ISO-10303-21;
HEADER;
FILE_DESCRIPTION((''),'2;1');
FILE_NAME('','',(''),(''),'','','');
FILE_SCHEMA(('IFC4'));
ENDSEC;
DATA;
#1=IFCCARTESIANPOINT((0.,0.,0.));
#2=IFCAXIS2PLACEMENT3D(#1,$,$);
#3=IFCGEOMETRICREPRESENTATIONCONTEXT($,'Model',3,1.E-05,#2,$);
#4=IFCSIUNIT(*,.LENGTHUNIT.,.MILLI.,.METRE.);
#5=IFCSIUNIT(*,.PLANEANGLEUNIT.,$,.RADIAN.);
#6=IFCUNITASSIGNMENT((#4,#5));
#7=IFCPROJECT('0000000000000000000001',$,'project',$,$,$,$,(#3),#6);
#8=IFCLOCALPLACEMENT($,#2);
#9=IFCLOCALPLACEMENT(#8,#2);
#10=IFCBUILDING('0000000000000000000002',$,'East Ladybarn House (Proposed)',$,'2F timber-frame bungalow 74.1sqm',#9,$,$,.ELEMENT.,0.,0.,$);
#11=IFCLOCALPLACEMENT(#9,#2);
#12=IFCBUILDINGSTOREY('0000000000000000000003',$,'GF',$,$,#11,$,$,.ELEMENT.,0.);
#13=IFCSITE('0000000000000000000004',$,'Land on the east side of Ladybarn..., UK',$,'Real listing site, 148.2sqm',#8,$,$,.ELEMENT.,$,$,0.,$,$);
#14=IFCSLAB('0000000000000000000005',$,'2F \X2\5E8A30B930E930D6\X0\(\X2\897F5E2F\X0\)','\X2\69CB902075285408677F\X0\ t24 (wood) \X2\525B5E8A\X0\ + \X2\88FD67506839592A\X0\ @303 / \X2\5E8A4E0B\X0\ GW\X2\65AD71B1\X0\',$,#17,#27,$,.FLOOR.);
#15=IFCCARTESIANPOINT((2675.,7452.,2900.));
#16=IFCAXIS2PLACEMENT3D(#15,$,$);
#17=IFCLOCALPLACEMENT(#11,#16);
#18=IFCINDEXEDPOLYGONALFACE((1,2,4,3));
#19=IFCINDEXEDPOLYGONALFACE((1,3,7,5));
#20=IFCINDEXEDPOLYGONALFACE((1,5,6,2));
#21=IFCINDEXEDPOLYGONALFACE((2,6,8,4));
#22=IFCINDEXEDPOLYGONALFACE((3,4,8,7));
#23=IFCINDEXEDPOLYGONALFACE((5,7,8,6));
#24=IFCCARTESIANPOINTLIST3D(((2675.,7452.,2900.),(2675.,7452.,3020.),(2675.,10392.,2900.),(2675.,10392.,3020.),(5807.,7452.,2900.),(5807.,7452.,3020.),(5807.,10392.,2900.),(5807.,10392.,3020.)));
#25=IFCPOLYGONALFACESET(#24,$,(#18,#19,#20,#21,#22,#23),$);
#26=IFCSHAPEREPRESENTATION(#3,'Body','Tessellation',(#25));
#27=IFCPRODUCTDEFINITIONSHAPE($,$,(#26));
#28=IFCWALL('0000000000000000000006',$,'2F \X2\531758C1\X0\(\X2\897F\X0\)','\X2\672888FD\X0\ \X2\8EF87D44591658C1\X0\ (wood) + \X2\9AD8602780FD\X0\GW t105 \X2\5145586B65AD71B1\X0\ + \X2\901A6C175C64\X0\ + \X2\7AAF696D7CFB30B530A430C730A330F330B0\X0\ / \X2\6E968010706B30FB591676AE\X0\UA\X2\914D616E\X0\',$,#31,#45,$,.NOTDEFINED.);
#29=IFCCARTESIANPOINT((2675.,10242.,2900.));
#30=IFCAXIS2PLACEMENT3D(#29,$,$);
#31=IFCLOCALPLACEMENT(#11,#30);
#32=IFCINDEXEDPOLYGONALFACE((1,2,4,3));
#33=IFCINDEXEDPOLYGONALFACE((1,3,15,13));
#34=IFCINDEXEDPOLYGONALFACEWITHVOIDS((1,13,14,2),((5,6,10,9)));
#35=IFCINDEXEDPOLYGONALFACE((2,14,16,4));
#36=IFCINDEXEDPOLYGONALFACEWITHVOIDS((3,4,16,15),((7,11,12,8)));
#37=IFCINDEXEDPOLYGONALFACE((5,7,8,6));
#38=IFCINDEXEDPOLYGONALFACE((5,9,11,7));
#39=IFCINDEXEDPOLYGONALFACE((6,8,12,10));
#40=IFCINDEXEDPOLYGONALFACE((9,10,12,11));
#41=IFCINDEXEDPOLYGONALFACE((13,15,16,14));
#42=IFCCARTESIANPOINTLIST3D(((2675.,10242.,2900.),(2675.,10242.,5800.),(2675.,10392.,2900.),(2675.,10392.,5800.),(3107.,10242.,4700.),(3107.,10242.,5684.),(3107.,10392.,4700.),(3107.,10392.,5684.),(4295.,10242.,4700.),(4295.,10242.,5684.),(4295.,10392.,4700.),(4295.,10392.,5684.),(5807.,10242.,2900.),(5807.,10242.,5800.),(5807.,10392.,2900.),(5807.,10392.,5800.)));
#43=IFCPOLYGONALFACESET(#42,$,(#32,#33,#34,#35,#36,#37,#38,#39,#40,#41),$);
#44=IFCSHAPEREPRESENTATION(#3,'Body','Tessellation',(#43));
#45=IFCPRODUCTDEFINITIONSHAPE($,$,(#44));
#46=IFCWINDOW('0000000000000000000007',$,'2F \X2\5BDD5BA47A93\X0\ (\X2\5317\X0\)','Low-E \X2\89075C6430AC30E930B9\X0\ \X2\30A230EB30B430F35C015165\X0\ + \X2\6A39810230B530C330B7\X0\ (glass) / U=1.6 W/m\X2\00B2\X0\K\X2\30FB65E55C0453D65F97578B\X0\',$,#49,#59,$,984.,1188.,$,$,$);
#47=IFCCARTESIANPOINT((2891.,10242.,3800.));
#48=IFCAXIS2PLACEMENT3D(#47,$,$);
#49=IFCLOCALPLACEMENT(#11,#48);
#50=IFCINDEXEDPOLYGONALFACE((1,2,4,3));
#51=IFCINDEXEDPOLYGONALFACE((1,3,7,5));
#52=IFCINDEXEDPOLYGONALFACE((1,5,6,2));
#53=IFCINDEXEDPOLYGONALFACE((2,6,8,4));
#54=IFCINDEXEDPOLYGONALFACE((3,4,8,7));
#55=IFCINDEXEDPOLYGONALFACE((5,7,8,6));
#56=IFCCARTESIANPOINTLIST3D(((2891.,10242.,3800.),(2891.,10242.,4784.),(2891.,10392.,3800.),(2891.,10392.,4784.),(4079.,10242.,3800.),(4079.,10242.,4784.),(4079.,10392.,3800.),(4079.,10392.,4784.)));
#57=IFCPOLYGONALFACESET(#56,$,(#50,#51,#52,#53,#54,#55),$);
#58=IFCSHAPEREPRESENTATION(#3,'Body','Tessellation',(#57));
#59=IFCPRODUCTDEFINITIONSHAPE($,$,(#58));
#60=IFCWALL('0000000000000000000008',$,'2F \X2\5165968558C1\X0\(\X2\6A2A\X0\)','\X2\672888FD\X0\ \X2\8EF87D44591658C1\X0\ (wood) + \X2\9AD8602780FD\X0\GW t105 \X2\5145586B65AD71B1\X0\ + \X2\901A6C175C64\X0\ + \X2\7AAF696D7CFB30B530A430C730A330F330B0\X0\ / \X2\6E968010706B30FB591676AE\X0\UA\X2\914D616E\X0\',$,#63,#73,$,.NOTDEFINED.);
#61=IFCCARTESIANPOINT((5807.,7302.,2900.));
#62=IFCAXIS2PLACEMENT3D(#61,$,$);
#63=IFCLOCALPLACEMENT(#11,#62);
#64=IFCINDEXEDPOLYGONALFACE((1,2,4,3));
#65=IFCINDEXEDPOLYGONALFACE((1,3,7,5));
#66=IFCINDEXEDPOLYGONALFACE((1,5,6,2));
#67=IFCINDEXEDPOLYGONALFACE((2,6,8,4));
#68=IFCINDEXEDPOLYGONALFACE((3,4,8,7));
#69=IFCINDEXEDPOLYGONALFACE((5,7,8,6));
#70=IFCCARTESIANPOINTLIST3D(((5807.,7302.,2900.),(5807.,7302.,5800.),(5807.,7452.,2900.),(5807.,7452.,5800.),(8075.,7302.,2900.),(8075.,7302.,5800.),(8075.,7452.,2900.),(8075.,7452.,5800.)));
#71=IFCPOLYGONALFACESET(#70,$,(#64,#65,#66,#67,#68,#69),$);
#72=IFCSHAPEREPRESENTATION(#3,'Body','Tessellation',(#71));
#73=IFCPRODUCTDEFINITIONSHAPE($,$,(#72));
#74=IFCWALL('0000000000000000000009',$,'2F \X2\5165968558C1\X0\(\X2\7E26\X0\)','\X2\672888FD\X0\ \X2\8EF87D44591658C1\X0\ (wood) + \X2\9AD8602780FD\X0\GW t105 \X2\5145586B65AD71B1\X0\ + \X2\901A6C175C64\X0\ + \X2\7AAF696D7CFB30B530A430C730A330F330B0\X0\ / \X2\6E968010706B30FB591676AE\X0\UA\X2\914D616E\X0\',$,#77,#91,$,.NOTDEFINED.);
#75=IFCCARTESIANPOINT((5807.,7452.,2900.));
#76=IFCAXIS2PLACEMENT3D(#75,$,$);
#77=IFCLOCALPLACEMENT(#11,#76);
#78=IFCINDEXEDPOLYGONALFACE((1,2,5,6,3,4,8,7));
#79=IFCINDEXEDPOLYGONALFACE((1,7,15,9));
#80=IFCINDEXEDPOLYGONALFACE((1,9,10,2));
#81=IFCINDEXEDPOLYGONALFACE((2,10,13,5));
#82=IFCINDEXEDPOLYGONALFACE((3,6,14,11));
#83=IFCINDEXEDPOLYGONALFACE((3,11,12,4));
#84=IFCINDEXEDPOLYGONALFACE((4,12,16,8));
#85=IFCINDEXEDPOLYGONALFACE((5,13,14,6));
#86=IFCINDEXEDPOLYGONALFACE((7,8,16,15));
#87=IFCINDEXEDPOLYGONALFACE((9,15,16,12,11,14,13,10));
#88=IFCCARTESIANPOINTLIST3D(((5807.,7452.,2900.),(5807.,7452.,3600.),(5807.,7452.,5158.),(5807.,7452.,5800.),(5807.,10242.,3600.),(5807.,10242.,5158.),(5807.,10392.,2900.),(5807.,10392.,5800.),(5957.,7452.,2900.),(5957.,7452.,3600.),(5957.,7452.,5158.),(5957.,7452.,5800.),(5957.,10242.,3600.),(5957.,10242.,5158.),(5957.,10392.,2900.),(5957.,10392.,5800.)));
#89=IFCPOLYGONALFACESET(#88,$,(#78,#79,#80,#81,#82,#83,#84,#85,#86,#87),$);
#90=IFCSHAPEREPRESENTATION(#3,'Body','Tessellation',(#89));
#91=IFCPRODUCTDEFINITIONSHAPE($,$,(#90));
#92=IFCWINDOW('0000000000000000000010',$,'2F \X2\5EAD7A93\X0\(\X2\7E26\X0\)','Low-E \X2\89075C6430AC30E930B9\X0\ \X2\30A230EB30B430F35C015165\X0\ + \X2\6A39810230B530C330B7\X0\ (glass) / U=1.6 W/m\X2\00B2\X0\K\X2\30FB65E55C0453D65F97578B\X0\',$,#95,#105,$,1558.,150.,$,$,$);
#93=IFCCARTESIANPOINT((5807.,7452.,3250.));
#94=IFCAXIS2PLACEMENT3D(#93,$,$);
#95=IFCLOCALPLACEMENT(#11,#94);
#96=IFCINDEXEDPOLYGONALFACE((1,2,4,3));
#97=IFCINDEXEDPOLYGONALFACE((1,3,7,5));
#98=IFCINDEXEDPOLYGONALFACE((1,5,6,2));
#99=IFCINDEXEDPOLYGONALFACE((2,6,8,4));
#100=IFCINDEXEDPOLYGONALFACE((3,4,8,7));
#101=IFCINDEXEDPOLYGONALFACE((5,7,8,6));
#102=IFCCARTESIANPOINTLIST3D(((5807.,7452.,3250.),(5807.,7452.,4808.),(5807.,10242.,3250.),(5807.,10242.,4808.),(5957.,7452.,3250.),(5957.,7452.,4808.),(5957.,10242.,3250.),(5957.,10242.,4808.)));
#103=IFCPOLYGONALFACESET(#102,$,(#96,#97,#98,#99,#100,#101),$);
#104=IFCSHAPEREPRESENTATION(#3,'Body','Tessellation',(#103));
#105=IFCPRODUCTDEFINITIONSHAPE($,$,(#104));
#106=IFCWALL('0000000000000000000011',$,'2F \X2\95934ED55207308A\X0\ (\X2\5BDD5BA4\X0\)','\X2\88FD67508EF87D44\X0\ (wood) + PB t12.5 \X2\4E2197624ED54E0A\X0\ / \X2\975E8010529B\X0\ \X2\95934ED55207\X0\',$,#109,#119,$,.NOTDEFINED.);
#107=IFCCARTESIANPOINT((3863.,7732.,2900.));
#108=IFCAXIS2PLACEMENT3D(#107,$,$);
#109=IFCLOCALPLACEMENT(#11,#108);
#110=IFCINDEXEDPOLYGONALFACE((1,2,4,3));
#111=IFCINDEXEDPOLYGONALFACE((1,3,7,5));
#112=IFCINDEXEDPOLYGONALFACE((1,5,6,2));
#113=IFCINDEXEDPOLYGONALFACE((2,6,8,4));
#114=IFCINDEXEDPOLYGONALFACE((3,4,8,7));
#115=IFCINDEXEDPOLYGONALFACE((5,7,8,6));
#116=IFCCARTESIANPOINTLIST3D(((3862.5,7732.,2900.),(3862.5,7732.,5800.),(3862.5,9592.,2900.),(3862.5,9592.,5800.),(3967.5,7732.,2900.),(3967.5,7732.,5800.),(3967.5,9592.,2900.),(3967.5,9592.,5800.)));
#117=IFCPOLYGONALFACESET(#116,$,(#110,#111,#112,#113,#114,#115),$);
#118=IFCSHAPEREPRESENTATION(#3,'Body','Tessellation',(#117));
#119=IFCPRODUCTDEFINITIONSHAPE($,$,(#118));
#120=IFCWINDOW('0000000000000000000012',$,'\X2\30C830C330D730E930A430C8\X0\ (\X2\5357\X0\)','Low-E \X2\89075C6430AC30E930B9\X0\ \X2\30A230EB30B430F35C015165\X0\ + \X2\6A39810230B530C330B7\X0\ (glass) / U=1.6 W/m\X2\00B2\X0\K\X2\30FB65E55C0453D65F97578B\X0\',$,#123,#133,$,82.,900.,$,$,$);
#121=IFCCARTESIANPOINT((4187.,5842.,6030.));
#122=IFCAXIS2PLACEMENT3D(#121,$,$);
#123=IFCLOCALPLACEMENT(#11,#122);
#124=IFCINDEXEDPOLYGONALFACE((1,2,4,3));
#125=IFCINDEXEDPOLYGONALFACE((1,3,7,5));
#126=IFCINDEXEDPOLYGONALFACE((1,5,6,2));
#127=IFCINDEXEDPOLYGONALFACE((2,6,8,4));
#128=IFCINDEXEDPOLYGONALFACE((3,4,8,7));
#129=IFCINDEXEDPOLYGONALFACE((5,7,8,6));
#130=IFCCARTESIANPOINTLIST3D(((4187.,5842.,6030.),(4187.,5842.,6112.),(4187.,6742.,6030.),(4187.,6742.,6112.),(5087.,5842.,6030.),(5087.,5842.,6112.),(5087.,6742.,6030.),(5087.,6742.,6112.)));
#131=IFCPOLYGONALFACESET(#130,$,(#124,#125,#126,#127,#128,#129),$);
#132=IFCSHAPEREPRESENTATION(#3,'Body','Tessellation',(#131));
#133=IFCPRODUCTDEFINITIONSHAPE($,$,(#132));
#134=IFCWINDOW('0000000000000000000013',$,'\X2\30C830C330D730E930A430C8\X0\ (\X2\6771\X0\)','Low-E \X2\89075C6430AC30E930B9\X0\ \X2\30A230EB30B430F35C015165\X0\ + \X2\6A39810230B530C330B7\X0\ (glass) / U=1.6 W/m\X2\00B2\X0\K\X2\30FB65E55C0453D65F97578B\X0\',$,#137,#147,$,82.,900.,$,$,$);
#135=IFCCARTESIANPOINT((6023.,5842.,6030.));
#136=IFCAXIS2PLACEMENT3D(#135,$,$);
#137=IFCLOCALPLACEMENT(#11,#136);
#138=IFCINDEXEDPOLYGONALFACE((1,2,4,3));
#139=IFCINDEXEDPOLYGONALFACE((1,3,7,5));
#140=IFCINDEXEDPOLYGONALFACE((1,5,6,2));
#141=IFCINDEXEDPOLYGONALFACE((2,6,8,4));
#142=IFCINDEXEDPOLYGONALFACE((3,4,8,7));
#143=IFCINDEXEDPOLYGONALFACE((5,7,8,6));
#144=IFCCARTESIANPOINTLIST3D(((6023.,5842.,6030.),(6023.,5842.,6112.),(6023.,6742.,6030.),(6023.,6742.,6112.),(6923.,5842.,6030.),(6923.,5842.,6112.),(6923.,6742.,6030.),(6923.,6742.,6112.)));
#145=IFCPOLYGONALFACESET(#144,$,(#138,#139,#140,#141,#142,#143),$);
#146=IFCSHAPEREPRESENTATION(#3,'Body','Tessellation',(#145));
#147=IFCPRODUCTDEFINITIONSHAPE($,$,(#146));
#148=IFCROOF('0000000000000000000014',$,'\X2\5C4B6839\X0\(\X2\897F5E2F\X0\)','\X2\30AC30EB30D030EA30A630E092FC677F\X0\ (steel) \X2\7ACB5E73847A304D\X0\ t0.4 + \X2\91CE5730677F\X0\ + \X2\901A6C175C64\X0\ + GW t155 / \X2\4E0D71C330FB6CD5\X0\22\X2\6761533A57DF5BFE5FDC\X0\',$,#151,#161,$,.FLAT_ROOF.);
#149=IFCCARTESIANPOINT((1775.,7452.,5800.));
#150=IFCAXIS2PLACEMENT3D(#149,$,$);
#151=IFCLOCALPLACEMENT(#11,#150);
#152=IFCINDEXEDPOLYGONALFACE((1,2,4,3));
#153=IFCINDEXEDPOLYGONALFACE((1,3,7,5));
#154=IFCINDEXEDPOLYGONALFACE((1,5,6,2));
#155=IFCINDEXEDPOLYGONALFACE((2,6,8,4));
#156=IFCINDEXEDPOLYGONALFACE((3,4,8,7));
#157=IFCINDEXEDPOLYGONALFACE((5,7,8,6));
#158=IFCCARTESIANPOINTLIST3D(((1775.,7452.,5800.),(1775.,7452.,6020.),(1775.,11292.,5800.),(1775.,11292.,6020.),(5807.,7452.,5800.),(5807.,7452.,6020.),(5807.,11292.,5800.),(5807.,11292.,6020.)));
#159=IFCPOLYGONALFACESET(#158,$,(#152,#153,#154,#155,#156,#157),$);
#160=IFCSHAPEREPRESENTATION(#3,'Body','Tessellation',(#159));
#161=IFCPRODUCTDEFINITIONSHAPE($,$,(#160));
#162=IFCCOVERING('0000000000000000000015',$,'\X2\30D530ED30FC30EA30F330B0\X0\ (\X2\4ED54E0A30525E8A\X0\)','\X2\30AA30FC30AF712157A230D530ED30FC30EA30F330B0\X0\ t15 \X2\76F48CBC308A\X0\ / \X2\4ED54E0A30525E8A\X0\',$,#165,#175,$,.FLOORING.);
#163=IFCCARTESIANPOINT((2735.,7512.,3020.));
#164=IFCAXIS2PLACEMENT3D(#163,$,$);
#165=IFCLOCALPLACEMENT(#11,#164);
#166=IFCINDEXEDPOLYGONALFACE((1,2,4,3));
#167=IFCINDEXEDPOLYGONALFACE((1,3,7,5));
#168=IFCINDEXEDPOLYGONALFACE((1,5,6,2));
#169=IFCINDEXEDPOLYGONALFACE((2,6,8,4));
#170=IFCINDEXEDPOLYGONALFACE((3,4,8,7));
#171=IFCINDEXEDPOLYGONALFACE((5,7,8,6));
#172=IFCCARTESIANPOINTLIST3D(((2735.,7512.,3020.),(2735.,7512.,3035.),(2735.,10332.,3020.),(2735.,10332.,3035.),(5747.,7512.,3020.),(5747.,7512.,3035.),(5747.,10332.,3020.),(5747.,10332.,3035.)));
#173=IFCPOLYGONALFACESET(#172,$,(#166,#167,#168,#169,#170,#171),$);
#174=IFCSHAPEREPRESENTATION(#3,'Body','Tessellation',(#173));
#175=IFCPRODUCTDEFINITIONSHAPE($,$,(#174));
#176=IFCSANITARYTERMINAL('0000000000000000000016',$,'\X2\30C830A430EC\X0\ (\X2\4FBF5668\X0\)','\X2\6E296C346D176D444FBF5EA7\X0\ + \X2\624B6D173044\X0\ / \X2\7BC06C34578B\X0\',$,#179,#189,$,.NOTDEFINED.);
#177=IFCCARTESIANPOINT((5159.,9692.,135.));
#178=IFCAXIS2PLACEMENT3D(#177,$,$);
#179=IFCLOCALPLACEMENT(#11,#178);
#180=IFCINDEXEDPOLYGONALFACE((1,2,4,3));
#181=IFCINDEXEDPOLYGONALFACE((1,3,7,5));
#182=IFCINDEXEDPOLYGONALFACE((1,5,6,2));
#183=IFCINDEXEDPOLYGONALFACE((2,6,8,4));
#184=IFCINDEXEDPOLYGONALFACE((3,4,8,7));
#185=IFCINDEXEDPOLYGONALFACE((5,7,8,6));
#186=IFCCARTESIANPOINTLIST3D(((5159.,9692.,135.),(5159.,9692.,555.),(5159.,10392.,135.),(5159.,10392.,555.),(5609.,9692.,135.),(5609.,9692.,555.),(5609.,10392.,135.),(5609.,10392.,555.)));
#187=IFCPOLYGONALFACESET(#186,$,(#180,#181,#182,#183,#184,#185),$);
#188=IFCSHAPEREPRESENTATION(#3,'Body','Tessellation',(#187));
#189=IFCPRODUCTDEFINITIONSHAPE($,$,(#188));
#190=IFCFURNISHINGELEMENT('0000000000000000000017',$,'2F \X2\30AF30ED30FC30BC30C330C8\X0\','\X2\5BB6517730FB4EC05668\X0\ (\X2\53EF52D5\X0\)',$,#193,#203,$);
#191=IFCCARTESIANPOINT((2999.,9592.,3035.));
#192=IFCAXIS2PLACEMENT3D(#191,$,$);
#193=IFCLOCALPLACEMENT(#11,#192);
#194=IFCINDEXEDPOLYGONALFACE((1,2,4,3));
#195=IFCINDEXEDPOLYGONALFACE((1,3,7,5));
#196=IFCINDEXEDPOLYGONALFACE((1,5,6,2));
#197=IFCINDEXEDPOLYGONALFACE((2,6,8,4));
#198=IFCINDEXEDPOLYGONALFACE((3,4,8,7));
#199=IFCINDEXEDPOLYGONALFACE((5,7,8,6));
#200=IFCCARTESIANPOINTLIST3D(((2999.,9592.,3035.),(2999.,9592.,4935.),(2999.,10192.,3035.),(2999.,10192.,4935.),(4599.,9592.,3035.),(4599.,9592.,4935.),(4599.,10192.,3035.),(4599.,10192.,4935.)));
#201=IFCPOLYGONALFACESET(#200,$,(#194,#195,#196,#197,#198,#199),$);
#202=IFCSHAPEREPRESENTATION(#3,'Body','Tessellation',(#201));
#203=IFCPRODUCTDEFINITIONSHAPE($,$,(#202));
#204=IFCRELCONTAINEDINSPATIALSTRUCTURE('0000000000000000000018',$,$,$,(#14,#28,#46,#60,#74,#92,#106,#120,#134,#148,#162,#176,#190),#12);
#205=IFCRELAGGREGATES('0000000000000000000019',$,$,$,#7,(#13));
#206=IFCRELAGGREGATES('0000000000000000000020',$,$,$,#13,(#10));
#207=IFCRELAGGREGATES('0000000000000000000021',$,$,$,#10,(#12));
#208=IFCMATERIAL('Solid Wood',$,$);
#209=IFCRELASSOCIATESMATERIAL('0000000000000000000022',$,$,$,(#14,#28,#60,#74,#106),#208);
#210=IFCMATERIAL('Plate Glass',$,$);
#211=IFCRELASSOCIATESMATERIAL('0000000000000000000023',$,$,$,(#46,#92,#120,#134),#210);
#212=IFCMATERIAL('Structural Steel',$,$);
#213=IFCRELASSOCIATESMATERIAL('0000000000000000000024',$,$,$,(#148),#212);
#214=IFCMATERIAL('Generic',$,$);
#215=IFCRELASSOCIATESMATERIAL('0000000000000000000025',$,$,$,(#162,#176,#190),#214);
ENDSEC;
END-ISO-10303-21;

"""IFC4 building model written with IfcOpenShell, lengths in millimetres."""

from ifc_helpers import new_model, si_unit, frame, frame_2d, origin, place, context, project, spatial, rectangle, extrude, material, element, fill, save


model = new_model("IFC4")

# Units and contexts
model_context = context("Model", 3, precision=1e-05, world=origin())
ifc_project = project(units=[si_unit("LENGTHUNIT", "METRE", prefix="MILLI"), si_unit("PLANEANGLEUNIT", "RADIAN")], contexts=[model_context])

# Site, building, storey
site_placement = place(None, origin())
site = spatial("IfcSite", under=ifc_project, at=site_placement, Name="Land on the east side of Ladybarn..., UK", ObjectType="Real listing site, 148.2sqm", CompositionType="ELEMENT", RefElevation=0.0)
building_placement = place(site_placement, origin())
building = spatial("IfcBuilding", under=site, at=building_placement, Name="East Ladybarn House (Proposed)", ObjectType="2F timber-frame bungalow 74.1sqm", CompositionType="ELEMENT", ElevationOfRefHeight=0.0, ElevationOfTerrain=0.0)
storey_placement = place(building_placement, origin())
storey = spatial("IfcBuildingStorey", under=building, at=storey_placement, Name="GF", CompositionType="ELEMENT", Elevation=0.0)

# Slab
ifc_material_1 = material(Name="Solid Wood")
slab_placement = place(storey_placement, frame((2675.0, 7452.0, 2900.0)))
element("IfcSlab", 1, at=slab_placement, inside=storey, material=ifc_material_1, Name="2F 床スラブ(西帯)", Description="構造用合板 t24 (wood) 剛床 + 製材根太 @303 / 床下 GW断熱", PredefinedType="FLOOR", context=model_context, shape_type="SweptSolid", body=[
    extrude(rectangle(XDim=3132.0, YDim=2940.0, at=frame_2d((1566.0, 1470.0))), frame((2675.0, 7452.0, 2900.0)), (0.0, 0.0, 1.0), 120.0),
])

# Wall, opening, window
wall_1_placement = place(storey_placement, frame((2675.0, 10242.0, 2900.0)))
wall_1 = element("IfcWall", 2, at=wall_1_placement, inside=storey, material=ifc_material_1, Name="2F 北壁(西)", Description="木製 軸組外壁 (wood) + 高性能GW t105 充填断熱 + 通気層 + 窯業系サイディング / 準耐火・外皮UA配慮", PredefinedType="NOTDEFINED", context=model_context, shape_type="SweptSolid", body=[
    extrude(rectangle(XDim=3132.0, YDim=150.0, at=frame_2d((1566.0, 75.0))), frame((2675.0, 10242.0, 2900.0)), (0.0, 0.0, 1.0), 2900.0),
])
opening_1_placement = place(storey_placement, frame((2891.0, 10242.0, 3800.0)))
opening_1 = element("IfcOpeningElement", 3, at=opening_1_placement, cuts=wall_1, PredefinedType="NOTDEFINED", context=model_context, shape_type="SweptSolid", body=[
    extrude(rectangle(XDim=1188.0, YDim=150.0, at=frame_2d((594.0, 75.0))), frame((2891.0, 10242.0, 3800.0)), (0.0, 0.0, 1.0), 984.0),
])
ifc_material_2 = material(Name="Plate Glass")
window_1_placement = place(storey_placement, frame((2891.0, 10242.0, 3800.0)))
window_1 = element("IfcWindow", 4, at=window_1_placement, inside=storey, material=ifc_material_2, Name="2F 寝室窓 (北)", Description="Low-E 複層ガラス アルゴン封入 + 樹脂サッシ (glass) / U=1.6 W/m²K・日射取得型", OverallHeight=984.0, OverallWidth=1188.0, context=model_context, shape_type="SweptSolid", body=[
    extrude(rectangle(XDim=1188.0, YDim=150.0, at=frame_2d((594.0, 75.0))), frame((2891.0, 10242.0, 3800.0)), (0.0, 0.0, 1.0), 984.0),
])
fill(opening_1, window_1)

# Wall
wall_2_placement = place(storey_placement, frame((5807.0, 7302.0, 2900.0)))
element("IfcWall", 5, at=wall_2_placement, inside=storey, material=ifc_material_1, Name="2F 入隅壁(横)", Description="木製 軸組外壁 (wood) + 高性能GW t105 充填断熱 + 通気層 + 窯業系サイディング / 準耐火・外皮UA配慮", PredefinedType="NOTDEFINED", context=model_context, shape_type="SweptSolid", body=[
    extrude(rectangle(XDim=2268.0, YDim=150.0, at=frame_2d((1134.0, 75.0))), frame((5807.0, 7302.0, 2900.0)), (0.0, 0.0, 1.0), 2900.0),
])

# Wall, opening, window
wall_3_placement = place(storey_placement, frame((5807.0, 7452.0, 2900.0)))
wall_3 = element("IfcWall", 6, at=wall_3_placement, inside=storey, material=ifc_material_1, Name="2F 入隅壁(縦)", Description="木製 軸組外壁 (wood) + 高性能GW t105 充填断熱 + 通気層 + 窯業系サイディング / 準耐火・外皮UA配慮", PredefinedType="NOTDEFINED", context=model_context, shape_type="SweptSolid", body=[
    extrude(rectangle(XDim=150.0, YDim=2940.0, at=frame_2d((75.0, 1470.0))), frame((5807.0, 7452.0, 2900.0)), (0.0, 0.0, 1.0), 2900.0),
])
opening_2_placement = place(storey_placement, frame((5807.0, 7452.0, 3250.0)))
opening_2 = element("IfcOpeningElement", 7, at=opening_2_placement, cuts=wall_3, PredefinedType="NOTDEFINED", context=model_context, shape_type="SweptSolid", body=[
    extrude(rectangle(XDim=150.0, YDim=2790.0, at=frame_2d((75.0, 1395.0))), frame((5807.0, 7452.0, 3250.0)), (0.0, 0.0, 1.0), 1558.0),
])
window_2_placement = place(storey_placement, frame((5807.0, 7452.0, 3250.0)))
window_2 = element("IfcWindow", 8, at=window_2_placement, inside=storey, material=ifc_material_2, Name="2F 庭窓(縦)", Description="Low-E 複層ガラス アルゴン封入 + 樹脂サッシ (glass) / U=1.6 W/m²K・日射取得型", OverallHeight=1558.0, OverallWidth=150.0, context=model_context, shape_type="SweptSolid", body=[
    extrude(rectangle(XDim=150.0, YDim=2790.0, at=frame_2d((75.0, 1395.0))), frame((5807.0, 7452.0, 3250.0)), (0.0, 0.0, 1.0), 1558.0),
])
fill(opening_2, window_2)

# Wall
wall_4_placement = place(storey_placement, frame((3863.0, 7732.0, 2900.0)))
element("IfcWall", 9, at=wall_4_placement, inside=storey, material=ifc_material_1, Name="2F 間仕切り (寝室)", Description="製材軸組 (wood) + PB t12.5 両面仕上 / 非耐力 間仕切", PredefinedType="NOTDEFINED", context=model_context, shape_type="SweptSolid", body=[
    extrude(rectangle(XDim=105.0, YDim=1860.0, at=frame_2d((52.0, 930.0))), frame((3863.0, 7732.0, 2900.0)), (0.0, 0.0, 1.0), 2900.0),
])

# Windows
window_3_placement = place(storey_placement, frame((4187.0, 5842.0, 6030.0)))
element("IfcWindow", 10, at=window_3_placement, inside=storey, material=ifc_material_2, Name="トップライト (南)", Description="Low-E 複層ガラス アルゴン封入 + 樹脂サッシ (glass) / U=1.6 W/m²K・日射取得型", OverallHeight=82.0, OverallWidth=900.0, context=model_context, shape_type="SweptSolid", body=[
    extrude(rectangle(XDim=900.0, YDim=900.0, at=frame_2d((450.0, 450.0))), frame((4187.0, 5842.0, 6030.0)), (0.0, 0.0, 1.0), 82.0),
])
window_4_placement = place(storey_placement, frame((6023.0, 5842.0, 6030.0)))
element("IfcWindow", 11, at=window_4_placement, inside=storey, material=ifc_material_2, Name="トップライト (東)", Description="Low-E 複層ガラス アルゴン封入 + 樹脂サッシ (glass) / U=1.6 W/m²K・日射取得型", OverallHeight=82.0, OverallWidth=900.0, context=model_context, shape_type="SweptSolid", body=[
    extrude(rectangle(XDim=900.0, YDim=900.0, at=frame_2d((450.0, 450.0))), frame((6023.0, 5842.0, 6030.0)), (0.0, 0.0, 1.0), 82.0),
])

# Roof
ifc_material_3 = material(Name="Structural Steel")
for number, where, name in (
    (12, (1775.0, 7452.0, 5800.0), "屋根(西帯)"),
):
    element("IfcRoof", number, at=place(storey_placement, frame(where)), inside=storey, material=ifc_material_3, Name=name, Description="ガルバリウム鋼板 (steel) 立平葺き t0.4 + 野地板 + 通気層 + GW t155 / 不燃・法22条区域対応", PredefinedType="FLAT_ROOF", context=model_context, shape_type="SweptSolid", body=[
        extrude(rectangle(XDim=4032.0, YDim=3840.0, at=frame_2d((2016.0, 1920.0))), frame((1775.0, 7452.0, 5800.0)), (0.0, 0.0, 1.0), 220.0),
    ])

# Covering
ifc_material_4 = material(Name="Generic")
covering_placement = place(storey_placement, frame((2735.0, 7512.0, 3020.0)))
element("IfcCovering", 13, at=covering_placement, inside=storey, material=ifc_material_4, Name="フローリング (仕上げ床)", Description="オーク無垢フローリング t15 直貼り / 仕上げ床", PredefinedType="FLOORING", context=model_context, shape_type="SweptSolid", body=[
    extrude(rectangle(XDim=3012.0, YDim=2820.0, at=frame_2d((1506.0, 1410.0))), frame((2735.0, 7512.0, 3020.0)), (0.0, 0.0, 1.0), 15.0),
])

# Sanitary terminal
sanitary_terminal_placement = place(storey_placement, frame((5159.0, 9692.0, 135.0)))
element("IfcSanitaryTerminal", 14, at=sanitary_terminal_placement, inside=storey, material=ifc_material_4, Name="トイレ (便器)", Description="温水洗浄便座 + 手洗い / 節水型", PredefinedType="NOTDEFINED", context=model_context, shape_type="SweptSolid", body=[
    extrude(rectangle(XDim=450.0, YDim=700.0, at=frame_2d((225.0, 350.0))), frame((5159.0, 9692.0, 135.0)), (0.0, 0.0, 1.0), 420.0),
])

# Furnishing element
furnishing_1_placement = place(storey_placement, frame((2999.0, 9592.0, 3035.0)))
element("IfcFurnishingElement", 15, at=furnishing_1_placement, inside=storey, material=ifc_material_4, Name="2F クローゼット", Description="家具・什器 (可動)", context=model_context, shape_type="SweptSolid", body=[
    extrude(rectangle(XDim=1600.0, YDim=600.0, at=frame_2d((800.0, 300.0))), frame((2999.0, 9592.0, 3035.0)), (0.0, 0.0, 1.0), 1900.0),
])

save(model, "model.ifc")
